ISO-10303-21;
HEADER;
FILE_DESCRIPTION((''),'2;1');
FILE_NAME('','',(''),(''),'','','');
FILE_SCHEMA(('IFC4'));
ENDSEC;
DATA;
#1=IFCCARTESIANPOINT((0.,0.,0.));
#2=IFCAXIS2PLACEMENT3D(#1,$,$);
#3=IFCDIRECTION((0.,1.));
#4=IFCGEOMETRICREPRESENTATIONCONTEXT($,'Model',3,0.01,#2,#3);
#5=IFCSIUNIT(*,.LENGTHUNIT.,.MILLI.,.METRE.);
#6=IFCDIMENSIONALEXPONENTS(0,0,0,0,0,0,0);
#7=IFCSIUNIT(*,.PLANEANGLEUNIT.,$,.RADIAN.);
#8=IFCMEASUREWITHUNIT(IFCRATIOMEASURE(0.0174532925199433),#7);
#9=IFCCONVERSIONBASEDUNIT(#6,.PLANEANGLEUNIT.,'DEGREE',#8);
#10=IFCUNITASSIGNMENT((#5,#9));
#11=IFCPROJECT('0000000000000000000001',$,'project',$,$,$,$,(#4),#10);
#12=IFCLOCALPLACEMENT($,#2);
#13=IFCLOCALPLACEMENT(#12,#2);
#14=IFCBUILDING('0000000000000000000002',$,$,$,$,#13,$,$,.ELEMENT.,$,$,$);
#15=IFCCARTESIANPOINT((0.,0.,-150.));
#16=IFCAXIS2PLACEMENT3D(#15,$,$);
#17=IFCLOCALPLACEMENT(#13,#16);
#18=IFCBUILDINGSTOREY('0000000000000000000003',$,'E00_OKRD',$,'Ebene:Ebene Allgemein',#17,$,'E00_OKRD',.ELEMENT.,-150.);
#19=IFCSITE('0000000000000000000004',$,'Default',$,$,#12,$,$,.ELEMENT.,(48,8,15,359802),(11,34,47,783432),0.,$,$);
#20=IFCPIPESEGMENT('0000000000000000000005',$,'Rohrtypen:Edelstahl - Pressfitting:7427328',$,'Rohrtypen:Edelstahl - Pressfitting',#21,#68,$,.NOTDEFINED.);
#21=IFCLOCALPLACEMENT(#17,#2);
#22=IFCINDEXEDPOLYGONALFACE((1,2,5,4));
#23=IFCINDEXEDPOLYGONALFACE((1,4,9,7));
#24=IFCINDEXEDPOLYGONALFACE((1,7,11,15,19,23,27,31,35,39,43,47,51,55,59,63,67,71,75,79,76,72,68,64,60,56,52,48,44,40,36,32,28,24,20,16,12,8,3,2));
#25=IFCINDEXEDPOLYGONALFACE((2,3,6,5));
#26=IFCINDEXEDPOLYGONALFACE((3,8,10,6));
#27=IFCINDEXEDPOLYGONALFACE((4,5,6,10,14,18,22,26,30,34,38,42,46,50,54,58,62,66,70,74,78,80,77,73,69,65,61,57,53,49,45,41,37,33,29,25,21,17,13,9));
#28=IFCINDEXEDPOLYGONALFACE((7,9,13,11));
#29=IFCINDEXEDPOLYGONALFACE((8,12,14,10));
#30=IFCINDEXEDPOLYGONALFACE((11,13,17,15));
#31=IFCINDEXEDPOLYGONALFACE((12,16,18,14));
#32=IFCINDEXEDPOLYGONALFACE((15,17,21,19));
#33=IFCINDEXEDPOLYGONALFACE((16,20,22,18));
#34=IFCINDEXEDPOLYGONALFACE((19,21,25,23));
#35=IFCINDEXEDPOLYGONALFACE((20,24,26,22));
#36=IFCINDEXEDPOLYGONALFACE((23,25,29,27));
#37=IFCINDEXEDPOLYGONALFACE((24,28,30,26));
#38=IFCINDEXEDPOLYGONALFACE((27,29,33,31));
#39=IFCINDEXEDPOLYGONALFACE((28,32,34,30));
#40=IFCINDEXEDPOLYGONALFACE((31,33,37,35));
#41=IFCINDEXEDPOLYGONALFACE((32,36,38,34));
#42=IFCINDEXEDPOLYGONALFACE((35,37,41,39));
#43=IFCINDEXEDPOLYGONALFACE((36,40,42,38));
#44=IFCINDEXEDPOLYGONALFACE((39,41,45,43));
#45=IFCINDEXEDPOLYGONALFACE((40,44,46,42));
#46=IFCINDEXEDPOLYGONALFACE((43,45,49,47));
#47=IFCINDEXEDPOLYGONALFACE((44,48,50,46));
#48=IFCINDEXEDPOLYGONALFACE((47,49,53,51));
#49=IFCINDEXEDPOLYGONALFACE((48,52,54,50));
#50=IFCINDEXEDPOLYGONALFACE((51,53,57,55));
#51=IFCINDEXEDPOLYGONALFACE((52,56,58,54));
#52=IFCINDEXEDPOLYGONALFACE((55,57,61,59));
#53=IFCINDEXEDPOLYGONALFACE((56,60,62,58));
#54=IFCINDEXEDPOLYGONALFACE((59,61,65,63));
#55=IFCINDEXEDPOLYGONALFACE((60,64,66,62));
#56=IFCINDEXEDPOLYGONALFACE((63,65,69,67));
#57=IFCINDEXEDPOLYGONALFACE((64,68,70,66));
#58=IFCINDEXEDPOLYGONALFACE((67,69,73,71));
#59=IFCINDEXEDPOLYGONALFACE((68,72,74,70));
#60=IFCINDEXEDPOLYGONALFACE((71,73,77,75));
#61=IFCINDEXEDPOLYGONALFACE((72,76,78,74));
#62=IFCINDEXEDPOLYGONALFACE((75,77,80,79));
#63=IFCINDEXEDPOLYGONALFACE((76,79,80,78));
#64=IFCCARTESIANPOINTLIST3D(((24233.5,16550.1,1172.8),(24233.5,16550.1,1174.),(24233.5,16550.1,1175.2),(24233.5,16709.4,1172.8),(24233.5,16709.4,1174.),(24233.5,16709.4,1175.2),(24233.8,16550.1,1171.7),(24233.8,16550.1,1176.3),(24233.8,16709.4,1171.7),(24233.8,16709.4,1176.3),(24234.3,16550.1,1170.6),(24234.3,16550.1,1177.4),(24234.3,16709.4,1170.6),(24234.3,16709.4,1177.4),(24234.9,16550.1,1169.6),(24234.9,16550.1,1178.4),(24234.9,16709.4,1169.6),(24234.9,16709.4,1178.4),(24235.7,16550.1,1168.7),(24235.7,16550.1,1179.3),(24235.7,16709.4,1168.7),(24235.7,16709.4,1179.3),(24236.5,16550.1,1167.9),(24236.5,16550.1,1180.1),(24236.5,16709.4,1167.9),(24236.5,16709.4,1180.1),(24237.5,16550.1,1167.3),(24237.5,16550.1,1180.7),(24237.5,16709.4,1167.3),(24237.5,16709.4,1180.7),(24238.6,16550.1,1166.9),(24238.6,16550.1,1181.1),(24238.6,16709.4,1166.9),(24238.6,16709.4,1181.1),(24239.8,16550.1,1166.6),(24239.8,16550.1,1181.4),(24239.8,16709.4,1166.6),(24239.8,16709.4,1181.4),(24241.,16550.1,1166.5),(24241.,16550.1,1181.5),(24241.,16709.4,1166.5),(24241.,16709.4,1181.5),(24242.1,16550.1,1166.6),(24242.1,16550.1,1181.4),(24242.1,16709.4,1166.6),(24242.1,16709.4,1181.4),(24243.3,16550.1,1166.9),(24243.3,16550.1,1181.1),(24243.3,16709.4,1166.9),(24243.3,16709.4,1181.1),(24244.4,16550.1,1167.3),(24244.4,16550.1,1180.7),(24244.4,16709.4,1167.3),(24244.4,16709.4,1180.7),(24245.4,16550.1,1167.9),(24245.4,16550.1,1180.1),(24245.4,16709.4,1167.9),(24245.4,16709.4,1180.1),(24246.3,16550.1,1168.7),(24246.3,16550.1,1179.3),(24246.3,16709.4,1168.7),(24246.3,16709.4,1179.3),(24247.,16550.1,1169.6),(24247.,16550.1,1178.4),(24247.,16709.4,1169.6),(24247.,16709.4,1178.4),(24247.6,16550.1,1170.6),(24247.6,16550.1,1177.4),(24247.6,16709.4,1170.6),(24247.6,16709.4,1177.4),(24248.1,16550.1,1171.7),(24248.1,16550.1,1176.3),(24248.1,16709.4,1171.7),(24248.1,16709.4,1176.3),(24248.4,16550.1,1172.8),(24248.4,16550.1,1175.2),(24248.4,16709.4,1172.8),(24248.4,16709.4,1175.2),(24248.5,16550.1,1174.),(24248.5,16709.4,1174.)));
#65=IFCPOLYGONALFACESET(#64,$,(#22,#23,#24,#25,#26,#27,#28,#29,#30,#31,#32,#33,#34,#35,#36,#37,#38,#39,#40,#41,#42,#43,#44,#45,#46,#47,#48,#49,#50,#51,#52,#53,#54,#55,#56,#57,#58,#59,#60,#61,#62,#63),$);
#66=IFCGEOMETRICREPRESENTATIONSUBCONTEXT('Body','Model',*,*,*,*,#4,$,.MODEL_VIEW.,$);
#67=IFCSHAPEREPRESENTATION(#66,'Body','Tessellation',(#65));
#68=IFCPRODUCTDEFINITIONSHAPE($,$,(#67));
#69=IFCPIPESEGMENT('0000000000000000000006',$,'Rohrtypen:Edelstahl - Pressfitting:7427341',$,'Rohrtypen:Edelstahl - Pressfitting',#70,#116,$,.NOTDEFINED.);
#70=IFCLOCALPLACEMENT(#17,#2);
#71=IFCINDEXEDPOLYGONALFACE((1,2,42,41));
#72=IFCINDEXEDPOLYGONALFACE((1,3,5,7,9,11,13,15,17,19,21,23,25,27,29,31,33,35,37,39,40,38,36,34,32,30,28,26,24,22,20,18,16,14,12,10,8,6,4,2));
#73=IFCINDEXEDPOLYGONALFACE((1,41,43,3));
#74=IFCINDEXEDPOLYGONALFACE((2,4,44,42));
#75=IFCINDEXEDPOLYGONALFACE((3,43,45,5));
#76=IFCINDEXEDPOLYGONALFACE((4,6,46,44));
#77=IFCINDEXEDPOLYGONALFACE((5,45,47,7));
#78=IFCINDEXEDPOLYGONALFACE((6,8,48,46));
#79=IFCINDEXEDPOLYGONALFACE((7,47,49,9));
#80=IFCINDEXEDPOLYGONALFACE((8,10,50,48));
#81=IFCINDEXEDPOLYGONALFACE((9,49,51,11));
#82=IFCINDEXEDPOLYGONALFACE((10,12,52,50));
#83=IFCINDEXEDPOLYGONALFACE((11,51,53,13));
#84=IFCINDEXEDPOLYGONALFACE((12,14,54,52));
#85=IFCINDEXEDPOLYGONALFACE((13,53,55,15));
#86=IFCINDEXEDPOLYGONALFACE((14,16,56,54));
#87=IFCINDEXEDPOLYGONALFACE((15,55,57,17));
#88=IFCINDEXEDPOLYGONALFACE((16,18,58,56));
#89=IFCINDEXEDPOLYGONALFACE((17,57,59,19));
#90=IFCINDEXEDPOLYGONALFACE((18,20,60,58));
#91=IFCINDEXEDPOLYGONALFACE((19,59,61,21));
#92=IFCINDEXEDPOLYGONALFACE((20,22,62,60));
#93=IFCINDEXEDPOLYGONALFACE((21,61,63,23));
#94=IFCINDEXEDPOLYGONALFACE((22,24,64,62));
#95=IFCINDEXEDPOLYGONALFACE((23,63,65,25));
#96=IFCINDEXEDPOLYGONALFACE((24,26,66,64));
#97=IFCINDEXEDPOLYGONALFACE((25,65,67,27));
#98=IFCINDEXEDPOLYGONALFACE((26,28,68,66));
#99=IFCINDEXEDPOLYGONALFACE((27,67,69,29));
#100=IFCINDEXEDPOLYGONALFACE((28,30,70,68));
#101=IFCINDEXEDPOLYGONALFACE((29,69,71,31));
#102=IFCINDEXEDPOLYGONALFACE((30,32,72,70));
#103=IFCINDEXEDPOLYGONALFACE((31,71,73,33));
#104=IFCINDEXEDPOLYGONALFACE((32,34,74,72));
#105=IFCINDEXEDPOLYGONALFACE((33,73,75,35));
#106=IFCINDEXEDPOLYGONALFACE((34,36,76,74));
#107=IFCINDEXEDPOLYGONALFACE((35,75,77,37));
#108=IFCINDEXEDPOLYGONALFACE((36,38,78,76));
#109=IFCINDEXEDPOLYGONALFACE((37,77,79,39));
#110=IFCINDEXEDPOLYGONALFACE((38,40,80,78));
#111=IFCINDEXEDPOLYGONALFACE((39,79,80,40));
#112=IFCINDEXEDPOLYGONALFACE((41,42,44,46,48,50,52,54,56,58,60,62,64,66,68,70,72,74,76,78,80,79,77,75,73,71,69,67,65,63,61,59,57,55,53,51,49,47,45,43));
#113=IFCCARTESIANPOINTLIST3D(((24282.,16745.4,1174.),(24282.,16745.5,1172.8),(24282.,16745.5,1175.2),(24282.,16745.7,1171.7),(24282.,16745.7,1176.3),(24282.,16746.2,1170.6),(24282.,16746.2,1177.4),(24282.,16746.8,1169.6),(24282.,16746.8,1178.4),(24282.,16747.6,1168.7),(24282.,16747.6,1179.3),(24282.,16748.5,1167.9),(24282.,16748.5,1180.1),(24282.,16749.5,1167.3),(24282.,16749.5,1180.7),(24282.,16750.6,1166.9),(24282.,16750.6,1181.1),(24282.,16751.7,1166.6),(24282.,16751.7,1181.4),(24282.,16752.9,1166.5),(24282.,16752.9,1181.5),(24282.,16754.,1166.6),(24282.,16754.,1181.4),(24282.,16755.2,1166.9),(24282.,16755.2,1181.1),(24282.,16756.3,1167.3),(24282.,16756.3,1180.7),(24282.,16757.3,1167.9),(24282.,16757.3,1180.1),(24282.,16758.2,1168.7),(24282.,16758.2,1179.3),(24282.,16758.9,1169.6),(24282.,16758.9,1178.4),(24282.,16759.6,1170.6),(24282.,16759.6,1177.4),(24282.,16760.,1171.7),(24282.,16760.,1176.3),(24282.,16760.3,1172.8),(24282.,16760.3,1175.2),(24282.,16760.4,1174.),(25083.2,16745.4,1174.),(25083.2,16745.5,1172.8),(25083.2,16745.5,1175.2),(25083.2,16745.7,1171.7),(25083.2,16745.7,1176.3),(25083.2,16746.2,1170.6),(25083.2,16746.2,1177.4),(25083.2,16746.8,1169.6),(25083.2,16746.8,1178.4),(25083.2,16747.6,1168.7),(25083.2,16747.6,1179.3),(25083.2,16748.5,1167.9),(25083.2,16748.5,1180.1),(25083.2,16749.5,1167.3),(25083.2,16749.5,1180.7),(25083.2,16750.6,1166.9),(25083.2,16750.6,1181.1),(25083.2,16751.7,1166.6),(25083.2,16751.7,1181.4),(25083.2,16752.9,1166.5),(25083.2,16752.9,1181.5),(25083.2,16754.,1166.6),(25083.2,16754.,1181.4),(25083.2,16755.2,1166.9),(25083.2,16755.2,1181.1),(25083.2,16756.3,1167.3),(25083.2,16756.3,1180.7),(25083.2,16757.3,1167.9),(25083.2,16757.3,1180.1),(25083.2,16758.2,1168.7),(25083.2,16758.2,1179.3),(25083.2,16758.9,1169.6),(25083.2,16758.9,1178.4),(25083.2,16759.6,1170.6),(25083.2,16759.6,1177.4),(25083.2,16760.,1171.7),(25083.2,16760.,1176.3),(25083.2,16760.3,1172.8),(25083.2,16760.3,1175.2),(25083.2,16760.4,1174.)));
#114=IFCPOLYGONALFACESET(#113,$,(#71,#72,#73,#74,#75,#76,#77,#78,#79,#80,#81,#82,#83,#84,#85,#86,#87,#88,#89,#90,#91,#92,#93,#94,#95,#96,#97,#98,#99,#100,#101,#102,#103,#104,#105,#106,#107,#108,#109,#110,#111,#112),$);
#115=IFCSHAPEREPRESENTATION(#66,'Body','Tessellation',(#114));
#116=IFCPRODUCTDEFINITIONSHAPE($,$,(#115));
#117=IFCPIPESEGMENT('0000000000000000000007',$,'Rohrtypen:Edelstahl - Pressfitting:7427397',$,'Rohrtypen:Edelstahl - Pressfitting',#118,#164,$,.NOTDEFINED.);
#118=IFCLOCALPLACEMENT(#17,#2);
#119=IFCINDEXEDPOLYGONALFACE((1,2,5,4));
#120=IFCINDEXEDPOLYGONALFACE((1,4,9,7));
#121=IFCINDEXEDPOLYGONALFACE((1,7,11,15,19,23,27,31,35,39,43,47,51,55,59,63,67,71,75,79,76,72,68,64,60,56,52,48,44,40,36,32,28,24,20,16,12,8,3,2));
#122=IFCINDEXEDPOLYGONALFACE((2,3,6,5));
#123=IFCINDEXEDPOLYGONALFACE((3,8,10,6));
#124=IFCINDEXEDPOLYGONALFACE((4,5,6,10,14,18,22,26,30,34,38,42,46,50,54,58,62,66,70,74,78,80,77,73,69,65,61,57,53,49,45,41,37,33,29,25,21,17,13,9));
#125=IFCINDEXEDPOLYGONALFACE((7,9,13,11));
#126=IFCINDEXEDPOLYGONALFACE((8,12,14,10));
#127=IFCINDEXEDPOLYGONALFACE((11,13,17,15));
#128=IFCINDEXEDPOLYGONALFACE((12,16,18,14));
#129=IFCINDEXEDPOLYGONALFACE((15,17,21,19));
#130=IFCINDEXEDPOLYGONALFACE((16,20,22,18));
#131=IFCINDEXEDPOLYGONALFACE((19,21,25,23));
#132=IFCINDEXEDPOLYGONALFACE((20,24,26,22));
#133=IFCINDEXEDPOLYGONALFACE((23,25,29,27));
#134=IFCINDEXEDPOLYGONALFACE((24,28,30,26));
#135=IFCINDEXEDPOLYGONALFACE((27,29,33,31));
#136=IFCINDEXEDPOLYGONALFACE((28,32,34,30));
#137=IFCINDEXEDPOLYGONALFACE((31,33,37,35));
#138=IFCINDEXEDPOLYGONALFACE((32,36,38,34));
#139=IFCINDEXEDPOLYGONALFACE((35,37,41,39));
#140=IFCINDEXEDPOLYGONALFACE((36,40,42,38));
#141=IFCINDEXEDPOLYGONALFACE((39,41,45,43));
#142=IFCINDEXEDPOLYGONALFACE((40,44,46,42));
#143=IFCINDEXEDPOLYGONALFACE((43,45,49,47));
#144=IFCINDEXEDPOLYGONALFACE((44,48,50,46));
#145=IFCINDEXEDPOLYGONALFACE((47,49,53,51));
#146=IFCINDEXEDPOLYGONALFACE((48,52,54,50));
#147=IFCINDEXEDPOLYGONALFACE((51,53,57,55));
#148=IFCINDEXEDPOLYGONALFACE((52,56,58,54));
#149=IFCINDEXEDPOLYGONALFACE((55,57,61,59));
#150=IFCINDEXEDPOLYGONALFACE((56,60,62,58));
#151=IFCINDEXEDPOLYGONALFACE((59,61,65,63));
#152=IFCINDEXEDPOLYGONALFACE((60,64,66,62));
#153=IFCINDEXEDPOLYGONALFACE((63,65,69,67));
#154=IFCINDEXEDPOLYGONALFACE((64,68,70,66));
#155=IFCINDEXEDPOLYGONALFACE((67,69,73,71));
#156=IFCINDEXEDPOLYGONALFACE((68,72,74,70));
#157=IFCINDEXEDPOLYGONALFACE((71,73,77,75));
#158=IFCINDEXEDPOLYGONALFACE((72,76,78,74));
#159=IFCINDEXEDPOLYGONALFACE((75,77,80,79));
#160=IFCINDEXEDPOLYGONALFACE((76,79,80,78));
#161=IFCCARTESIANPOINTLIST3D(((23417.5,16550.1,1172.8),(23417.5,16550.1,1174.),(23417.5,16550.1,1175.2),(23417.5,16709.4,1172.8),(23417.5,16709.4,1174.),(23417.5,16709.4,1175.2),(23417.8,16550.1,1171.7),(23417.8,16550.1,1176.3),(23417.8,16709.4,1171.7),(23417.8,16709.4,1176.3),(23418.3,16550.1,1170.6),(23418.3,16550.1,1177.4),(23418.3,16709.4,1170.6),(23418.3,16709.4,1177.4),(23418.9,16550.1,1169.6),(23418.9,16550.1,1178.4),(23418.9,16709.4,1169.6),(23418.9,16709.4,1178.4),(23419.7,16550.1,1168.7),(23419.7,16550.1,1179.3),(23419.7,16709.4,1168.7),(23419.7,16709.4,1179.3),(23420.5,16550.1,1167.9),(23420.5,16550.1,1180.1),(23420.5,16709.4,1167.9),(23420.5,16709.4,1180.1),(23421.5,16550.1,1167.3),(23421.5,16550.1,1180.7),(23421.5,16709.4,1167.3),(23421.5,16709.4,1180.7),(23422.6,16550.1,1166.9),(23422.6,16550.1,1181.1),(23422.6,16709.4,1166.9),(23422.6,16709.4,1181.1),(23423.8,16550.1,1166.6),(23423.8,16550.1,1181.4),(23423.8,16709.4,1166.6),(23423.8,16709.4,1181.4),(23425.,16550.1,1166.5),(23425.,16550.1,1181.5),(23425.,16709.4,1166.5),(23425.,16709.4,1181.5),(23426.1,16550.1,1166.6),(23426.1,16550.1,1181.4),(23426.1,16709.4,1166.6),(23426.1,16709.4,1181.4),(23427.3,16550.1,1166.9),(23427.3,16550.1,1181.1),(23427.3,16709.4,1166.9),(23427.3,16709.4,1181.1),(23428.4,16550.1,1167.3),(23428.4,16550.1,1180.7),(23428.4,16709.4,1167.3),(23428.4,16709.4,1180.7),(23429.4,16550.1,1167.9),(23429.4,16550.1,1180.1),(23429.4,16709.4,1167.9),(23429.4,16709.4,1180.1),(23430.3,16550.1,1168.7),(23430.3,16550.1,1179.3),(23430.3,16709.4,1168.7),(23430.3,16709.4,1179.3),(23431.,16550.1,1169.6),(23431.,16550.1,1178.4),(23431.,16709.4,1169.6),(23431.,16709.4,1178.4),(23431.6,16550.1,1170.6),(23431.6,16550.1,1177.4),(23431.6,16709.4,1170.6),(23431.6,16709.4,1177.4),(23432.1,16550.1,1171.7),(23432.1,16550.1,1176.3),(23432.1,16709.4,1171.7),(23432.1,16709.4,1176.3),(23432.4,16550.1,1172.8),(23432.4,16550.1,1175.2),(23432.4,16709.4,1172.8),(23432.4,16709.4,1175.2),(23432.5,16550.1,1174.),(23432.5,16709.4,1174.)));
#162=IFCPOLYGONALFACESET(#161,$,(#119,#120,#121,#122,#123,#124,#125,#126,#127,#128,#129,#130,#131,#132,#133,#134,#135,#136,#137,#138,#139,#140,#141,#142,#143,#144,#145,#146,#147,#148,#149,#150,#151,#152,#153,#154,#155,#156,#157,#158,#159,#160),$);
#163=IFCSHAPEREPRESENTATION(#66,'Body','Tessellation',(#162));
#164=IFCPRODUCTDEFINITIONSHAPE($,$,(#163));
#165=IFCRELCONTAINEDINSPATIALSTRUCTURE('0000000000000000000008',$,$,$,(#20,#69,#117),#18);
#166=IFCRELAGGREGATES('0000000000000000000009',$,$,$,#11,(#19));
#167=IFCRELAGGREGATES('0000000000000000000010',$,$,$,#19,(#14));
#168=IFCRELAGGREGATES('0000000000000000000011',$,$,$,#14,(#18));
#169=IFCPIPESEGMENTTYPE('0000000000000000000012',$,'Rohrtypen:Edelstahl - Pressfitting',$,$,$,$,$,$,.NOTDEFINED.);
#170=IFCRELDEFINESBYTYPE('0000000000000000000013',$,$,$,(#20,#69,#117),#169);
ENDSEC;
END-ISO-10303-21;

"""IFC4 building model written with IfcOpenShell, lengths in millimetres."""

from ifc_helpers import new_model, entity, si_unit, converted_unit, direction, frame, origin, place, context, subcontext, project, spatial, indexed_curve, outline, extrude, type_object, element, save


model = new_model("IFC4")

# Units and contexts
model_context = context("Model", 3, precision=0.01, world=origin(), true_north=direction((0.0, 1.0)))
body_context = subcontext(model_context, "Body", "Model", "MODEL_VIEW")
ifc_project = project(units=[si_unit("LENGTHUNIT", "METRE", prefix="MILLI"), converted_unit("PLANEANGLEUNIT", "DEGREE", entity("IfcRatioMeasure", 0.0174532925199433), si_unit("PLANEANGLEUNIT", "RADIAN"), dimensions=[0, 0, 0, 0, 0, 0, 0])], contexts=[model_context])

# Site, building, storey
site_placement = place(None, origin())
site = spatial("IfcSite", under=ifc_project, at=site_placement, Name="Default", CompositionType="ELEMENT", RefLatitude=(48, 8, 15, 359802), RefLongitude=(11, 34, 47, 783432), RefElevation=0.0)
building_placement = place(site_placement, origin())
building = spatial("IfcBuilding", under=site, at=building_placement, CompositionType="ELEMENT")
storey_placement = place(building_placement, frame((0.0, 0.0, -150.0)))
storey = spatial("IfcBuildingStorey", under=building, at=storey_placement, Name="E00_OKRD", ObjectType="Ebene:Ebene Allgemein", LongName="E00_OKRD", CompositionType="ELEMENT", Elevation=-150.0)

# Pipe segments
pipe_segment_type_1 = type_object("IfcPipeSegmentType", Name="Rohrtypen:Edelstahl - Pressfitting", PredefinedType="NOTDEFINED")
pipe_segment_1_placement = place(storey_placement, origin())
element("IfcPipeSegment", 1, at=pipe_segment_1_placement, inside=storey, type_object=pipe_segment_type_1, Name="Rohrtypen:Edelstahl - Pressfitting:7427328", ObjectType="Rohrtypen:Edelstahl - Pressfitting", PredefinedType="NOTDEFINED", context=body_context, shape_type="SweptSolid", body=[
    extrude(outline(indexed_curve([(7.5, 0.0), (7.4, 1.2), (7.1, 2.3), (6.7, 3.4), (6.1, 4.4), (5.3, 5.3), (4.4, 6.1), (3.4, 6.7), (2.3, 7.1), (1.2, 7.4), (0.0, 7.5), (-1.2, 7.4), (-2.3, 7.1), (-3.4, 6.7), (-4.4, 6.1), (-5.3, 5.3), (-6.1, 4.4), (-6.7, 3.4), (-7.1, 2.3), (-7.4, 1.2), (-7.5, 0.0), (-7.4, -1.2), (-7.1, -2.3), (-6.7, -3.4), (-6.1, -4.4), (-5.3, -5.3), (-4.4, -6.1), (-3.4, -6.7), (-2.3, -7.1), (-1.2, -7.4), (0.0, -7.5), (1.2, -7.4), (2.3, -7.1), (3.4, -6.7), (4.4, -6.1), (5.3, -5.3), (6.1, -4.4), (6.7, -3.4), (7.1, -2.3), (7.4, -1.2), (7.5, 0.0)], self_intersect=False)), frame((24241.0, 16550.1, 1174.0), z_axis=(0.0, 1.0, 0.000047), x_axis=(-1.0, 0.0, 0.0)), (0.0, 0.0, 1.0), 159.2),
])
pipe_segment_2_placement = place(storey_placement, origin())
element("IfcPipeSegment", 2, at=pipe_segment_2_placement, inside=storey, type_object=pipe_segment_type_1, Name="Rohrtypen:Edelstahl - Pressfitting:7427341", ObjectType="Rohrtypen:Edelstahl - Pressfitting", PredefinedType="NOTDEFINED", context=body_context, shape_type="SweptSolid", body=[
    extrude(outline(indexed_curve([(7.5, 0.0), (7.4, 1.2), (7.1, 2.3), (6.7, 3.4), (6.1, 4.4), (5.3, 5.3), (4.4, 6.1), (3.4, 6.7), (2.3, 7.1), (1.2, 7.4), (0.0, 7.5), (-1.2, 7.4), (-2.3, 7.1), (-3.4, 6.7), (-4.4, 6.1), (-5.3, 5.3), (-6.1, 4.4), (-6.7, 3.4), (-7.1, 2.3), (-7.4, 1.2), (-7.5, 0.0), (-7.4, -1.2), (-7.1, -2.3), (-6.7, -3.4), (-6.1, -4.4), (-5.3, -5.3), (-4.4, -6.1), (-3.4, -6.7), (-2.3, -7.1), (-1.2, -7.4), (0.0, -7.5), (1.2, -7.4), (2.3, -7.1), (3.4, -6.7), (4.4, -6.1), (5.3, -5.3), (6.1, -4.4), (6.7, -3.4), (7.1, -2.3), (7.4, -1.2), (7.5, 0.0)], self_intersect=False)), frame((25083.2, 16752.9, 1174.0), z_axis=(-1.0, 0.0, 0.000011), x_axis=(0.0, 1.0, 0.0)), (0.0, 0.0, 1.0), 801.3),
])
pipe_segment_3_placement = place(storey_placement, origin())
element("IfcPipeSegment", 3, at=pipe_segment_3_placement, inside=storey, type_object=pipe_segment_type_1, Name="Rohrtypen:Edelstahl - Pressfitting:7427397", ObjectType="Rohrtypen:Edelstahl - Pressfitting", PredefinedType="NOTDEFINED", context=body_context, shape_type="SweptSolid", body=[
    extrude(outline(indexed_curve([(7.5, 0.0), (7.4, 1.2), (7.1, 2.3), (6.7, 3.4), (6.1, 4.4), (5.3, 5.3), (4.4, 6.1), (3.4, 6.7), (2.3, 7.1), (1.2, 7.4), (0.0, 7.5), (-1.2, 7.4), (-2.3, 7.1), (-3.4, 6.7), (-4.4, 6.1), (-5.3, 5.3), (-6.1, 4.4), (-6.7, 3.4), (-7.1, 2.3), (-7.4, 1.2), (-7.5, 0.0), (-7.4, -1.2), (-7.1, -2.3), (-6.7, -3.4), (-6.1, -4.4), (-5.3, -5.3), (-4.4, -6.1), (-3.4, -6.7), (-2.3, -7.1), (-1.2, -7.4), (0.0, -7.5), (1.2, -7.4), (2.3, -7.1), (3.4, -6.7), (4.4, -6.1), (5.3, -5.3), (6.1, -4.4), (6.7, -3.4), (7.1, -2.3), (7.4, -1.2), (7.5, 0.0)], self_intersect=False)), frame((23425.0, 16550.1, 1174.0), z_axis=(0.0, 1.0, 0.000054), x_axis=(-1.0, 0.0, 0.0)), (0.0, 0.0, 1.0), 159.2),
])

save(model, "model.ifc")
